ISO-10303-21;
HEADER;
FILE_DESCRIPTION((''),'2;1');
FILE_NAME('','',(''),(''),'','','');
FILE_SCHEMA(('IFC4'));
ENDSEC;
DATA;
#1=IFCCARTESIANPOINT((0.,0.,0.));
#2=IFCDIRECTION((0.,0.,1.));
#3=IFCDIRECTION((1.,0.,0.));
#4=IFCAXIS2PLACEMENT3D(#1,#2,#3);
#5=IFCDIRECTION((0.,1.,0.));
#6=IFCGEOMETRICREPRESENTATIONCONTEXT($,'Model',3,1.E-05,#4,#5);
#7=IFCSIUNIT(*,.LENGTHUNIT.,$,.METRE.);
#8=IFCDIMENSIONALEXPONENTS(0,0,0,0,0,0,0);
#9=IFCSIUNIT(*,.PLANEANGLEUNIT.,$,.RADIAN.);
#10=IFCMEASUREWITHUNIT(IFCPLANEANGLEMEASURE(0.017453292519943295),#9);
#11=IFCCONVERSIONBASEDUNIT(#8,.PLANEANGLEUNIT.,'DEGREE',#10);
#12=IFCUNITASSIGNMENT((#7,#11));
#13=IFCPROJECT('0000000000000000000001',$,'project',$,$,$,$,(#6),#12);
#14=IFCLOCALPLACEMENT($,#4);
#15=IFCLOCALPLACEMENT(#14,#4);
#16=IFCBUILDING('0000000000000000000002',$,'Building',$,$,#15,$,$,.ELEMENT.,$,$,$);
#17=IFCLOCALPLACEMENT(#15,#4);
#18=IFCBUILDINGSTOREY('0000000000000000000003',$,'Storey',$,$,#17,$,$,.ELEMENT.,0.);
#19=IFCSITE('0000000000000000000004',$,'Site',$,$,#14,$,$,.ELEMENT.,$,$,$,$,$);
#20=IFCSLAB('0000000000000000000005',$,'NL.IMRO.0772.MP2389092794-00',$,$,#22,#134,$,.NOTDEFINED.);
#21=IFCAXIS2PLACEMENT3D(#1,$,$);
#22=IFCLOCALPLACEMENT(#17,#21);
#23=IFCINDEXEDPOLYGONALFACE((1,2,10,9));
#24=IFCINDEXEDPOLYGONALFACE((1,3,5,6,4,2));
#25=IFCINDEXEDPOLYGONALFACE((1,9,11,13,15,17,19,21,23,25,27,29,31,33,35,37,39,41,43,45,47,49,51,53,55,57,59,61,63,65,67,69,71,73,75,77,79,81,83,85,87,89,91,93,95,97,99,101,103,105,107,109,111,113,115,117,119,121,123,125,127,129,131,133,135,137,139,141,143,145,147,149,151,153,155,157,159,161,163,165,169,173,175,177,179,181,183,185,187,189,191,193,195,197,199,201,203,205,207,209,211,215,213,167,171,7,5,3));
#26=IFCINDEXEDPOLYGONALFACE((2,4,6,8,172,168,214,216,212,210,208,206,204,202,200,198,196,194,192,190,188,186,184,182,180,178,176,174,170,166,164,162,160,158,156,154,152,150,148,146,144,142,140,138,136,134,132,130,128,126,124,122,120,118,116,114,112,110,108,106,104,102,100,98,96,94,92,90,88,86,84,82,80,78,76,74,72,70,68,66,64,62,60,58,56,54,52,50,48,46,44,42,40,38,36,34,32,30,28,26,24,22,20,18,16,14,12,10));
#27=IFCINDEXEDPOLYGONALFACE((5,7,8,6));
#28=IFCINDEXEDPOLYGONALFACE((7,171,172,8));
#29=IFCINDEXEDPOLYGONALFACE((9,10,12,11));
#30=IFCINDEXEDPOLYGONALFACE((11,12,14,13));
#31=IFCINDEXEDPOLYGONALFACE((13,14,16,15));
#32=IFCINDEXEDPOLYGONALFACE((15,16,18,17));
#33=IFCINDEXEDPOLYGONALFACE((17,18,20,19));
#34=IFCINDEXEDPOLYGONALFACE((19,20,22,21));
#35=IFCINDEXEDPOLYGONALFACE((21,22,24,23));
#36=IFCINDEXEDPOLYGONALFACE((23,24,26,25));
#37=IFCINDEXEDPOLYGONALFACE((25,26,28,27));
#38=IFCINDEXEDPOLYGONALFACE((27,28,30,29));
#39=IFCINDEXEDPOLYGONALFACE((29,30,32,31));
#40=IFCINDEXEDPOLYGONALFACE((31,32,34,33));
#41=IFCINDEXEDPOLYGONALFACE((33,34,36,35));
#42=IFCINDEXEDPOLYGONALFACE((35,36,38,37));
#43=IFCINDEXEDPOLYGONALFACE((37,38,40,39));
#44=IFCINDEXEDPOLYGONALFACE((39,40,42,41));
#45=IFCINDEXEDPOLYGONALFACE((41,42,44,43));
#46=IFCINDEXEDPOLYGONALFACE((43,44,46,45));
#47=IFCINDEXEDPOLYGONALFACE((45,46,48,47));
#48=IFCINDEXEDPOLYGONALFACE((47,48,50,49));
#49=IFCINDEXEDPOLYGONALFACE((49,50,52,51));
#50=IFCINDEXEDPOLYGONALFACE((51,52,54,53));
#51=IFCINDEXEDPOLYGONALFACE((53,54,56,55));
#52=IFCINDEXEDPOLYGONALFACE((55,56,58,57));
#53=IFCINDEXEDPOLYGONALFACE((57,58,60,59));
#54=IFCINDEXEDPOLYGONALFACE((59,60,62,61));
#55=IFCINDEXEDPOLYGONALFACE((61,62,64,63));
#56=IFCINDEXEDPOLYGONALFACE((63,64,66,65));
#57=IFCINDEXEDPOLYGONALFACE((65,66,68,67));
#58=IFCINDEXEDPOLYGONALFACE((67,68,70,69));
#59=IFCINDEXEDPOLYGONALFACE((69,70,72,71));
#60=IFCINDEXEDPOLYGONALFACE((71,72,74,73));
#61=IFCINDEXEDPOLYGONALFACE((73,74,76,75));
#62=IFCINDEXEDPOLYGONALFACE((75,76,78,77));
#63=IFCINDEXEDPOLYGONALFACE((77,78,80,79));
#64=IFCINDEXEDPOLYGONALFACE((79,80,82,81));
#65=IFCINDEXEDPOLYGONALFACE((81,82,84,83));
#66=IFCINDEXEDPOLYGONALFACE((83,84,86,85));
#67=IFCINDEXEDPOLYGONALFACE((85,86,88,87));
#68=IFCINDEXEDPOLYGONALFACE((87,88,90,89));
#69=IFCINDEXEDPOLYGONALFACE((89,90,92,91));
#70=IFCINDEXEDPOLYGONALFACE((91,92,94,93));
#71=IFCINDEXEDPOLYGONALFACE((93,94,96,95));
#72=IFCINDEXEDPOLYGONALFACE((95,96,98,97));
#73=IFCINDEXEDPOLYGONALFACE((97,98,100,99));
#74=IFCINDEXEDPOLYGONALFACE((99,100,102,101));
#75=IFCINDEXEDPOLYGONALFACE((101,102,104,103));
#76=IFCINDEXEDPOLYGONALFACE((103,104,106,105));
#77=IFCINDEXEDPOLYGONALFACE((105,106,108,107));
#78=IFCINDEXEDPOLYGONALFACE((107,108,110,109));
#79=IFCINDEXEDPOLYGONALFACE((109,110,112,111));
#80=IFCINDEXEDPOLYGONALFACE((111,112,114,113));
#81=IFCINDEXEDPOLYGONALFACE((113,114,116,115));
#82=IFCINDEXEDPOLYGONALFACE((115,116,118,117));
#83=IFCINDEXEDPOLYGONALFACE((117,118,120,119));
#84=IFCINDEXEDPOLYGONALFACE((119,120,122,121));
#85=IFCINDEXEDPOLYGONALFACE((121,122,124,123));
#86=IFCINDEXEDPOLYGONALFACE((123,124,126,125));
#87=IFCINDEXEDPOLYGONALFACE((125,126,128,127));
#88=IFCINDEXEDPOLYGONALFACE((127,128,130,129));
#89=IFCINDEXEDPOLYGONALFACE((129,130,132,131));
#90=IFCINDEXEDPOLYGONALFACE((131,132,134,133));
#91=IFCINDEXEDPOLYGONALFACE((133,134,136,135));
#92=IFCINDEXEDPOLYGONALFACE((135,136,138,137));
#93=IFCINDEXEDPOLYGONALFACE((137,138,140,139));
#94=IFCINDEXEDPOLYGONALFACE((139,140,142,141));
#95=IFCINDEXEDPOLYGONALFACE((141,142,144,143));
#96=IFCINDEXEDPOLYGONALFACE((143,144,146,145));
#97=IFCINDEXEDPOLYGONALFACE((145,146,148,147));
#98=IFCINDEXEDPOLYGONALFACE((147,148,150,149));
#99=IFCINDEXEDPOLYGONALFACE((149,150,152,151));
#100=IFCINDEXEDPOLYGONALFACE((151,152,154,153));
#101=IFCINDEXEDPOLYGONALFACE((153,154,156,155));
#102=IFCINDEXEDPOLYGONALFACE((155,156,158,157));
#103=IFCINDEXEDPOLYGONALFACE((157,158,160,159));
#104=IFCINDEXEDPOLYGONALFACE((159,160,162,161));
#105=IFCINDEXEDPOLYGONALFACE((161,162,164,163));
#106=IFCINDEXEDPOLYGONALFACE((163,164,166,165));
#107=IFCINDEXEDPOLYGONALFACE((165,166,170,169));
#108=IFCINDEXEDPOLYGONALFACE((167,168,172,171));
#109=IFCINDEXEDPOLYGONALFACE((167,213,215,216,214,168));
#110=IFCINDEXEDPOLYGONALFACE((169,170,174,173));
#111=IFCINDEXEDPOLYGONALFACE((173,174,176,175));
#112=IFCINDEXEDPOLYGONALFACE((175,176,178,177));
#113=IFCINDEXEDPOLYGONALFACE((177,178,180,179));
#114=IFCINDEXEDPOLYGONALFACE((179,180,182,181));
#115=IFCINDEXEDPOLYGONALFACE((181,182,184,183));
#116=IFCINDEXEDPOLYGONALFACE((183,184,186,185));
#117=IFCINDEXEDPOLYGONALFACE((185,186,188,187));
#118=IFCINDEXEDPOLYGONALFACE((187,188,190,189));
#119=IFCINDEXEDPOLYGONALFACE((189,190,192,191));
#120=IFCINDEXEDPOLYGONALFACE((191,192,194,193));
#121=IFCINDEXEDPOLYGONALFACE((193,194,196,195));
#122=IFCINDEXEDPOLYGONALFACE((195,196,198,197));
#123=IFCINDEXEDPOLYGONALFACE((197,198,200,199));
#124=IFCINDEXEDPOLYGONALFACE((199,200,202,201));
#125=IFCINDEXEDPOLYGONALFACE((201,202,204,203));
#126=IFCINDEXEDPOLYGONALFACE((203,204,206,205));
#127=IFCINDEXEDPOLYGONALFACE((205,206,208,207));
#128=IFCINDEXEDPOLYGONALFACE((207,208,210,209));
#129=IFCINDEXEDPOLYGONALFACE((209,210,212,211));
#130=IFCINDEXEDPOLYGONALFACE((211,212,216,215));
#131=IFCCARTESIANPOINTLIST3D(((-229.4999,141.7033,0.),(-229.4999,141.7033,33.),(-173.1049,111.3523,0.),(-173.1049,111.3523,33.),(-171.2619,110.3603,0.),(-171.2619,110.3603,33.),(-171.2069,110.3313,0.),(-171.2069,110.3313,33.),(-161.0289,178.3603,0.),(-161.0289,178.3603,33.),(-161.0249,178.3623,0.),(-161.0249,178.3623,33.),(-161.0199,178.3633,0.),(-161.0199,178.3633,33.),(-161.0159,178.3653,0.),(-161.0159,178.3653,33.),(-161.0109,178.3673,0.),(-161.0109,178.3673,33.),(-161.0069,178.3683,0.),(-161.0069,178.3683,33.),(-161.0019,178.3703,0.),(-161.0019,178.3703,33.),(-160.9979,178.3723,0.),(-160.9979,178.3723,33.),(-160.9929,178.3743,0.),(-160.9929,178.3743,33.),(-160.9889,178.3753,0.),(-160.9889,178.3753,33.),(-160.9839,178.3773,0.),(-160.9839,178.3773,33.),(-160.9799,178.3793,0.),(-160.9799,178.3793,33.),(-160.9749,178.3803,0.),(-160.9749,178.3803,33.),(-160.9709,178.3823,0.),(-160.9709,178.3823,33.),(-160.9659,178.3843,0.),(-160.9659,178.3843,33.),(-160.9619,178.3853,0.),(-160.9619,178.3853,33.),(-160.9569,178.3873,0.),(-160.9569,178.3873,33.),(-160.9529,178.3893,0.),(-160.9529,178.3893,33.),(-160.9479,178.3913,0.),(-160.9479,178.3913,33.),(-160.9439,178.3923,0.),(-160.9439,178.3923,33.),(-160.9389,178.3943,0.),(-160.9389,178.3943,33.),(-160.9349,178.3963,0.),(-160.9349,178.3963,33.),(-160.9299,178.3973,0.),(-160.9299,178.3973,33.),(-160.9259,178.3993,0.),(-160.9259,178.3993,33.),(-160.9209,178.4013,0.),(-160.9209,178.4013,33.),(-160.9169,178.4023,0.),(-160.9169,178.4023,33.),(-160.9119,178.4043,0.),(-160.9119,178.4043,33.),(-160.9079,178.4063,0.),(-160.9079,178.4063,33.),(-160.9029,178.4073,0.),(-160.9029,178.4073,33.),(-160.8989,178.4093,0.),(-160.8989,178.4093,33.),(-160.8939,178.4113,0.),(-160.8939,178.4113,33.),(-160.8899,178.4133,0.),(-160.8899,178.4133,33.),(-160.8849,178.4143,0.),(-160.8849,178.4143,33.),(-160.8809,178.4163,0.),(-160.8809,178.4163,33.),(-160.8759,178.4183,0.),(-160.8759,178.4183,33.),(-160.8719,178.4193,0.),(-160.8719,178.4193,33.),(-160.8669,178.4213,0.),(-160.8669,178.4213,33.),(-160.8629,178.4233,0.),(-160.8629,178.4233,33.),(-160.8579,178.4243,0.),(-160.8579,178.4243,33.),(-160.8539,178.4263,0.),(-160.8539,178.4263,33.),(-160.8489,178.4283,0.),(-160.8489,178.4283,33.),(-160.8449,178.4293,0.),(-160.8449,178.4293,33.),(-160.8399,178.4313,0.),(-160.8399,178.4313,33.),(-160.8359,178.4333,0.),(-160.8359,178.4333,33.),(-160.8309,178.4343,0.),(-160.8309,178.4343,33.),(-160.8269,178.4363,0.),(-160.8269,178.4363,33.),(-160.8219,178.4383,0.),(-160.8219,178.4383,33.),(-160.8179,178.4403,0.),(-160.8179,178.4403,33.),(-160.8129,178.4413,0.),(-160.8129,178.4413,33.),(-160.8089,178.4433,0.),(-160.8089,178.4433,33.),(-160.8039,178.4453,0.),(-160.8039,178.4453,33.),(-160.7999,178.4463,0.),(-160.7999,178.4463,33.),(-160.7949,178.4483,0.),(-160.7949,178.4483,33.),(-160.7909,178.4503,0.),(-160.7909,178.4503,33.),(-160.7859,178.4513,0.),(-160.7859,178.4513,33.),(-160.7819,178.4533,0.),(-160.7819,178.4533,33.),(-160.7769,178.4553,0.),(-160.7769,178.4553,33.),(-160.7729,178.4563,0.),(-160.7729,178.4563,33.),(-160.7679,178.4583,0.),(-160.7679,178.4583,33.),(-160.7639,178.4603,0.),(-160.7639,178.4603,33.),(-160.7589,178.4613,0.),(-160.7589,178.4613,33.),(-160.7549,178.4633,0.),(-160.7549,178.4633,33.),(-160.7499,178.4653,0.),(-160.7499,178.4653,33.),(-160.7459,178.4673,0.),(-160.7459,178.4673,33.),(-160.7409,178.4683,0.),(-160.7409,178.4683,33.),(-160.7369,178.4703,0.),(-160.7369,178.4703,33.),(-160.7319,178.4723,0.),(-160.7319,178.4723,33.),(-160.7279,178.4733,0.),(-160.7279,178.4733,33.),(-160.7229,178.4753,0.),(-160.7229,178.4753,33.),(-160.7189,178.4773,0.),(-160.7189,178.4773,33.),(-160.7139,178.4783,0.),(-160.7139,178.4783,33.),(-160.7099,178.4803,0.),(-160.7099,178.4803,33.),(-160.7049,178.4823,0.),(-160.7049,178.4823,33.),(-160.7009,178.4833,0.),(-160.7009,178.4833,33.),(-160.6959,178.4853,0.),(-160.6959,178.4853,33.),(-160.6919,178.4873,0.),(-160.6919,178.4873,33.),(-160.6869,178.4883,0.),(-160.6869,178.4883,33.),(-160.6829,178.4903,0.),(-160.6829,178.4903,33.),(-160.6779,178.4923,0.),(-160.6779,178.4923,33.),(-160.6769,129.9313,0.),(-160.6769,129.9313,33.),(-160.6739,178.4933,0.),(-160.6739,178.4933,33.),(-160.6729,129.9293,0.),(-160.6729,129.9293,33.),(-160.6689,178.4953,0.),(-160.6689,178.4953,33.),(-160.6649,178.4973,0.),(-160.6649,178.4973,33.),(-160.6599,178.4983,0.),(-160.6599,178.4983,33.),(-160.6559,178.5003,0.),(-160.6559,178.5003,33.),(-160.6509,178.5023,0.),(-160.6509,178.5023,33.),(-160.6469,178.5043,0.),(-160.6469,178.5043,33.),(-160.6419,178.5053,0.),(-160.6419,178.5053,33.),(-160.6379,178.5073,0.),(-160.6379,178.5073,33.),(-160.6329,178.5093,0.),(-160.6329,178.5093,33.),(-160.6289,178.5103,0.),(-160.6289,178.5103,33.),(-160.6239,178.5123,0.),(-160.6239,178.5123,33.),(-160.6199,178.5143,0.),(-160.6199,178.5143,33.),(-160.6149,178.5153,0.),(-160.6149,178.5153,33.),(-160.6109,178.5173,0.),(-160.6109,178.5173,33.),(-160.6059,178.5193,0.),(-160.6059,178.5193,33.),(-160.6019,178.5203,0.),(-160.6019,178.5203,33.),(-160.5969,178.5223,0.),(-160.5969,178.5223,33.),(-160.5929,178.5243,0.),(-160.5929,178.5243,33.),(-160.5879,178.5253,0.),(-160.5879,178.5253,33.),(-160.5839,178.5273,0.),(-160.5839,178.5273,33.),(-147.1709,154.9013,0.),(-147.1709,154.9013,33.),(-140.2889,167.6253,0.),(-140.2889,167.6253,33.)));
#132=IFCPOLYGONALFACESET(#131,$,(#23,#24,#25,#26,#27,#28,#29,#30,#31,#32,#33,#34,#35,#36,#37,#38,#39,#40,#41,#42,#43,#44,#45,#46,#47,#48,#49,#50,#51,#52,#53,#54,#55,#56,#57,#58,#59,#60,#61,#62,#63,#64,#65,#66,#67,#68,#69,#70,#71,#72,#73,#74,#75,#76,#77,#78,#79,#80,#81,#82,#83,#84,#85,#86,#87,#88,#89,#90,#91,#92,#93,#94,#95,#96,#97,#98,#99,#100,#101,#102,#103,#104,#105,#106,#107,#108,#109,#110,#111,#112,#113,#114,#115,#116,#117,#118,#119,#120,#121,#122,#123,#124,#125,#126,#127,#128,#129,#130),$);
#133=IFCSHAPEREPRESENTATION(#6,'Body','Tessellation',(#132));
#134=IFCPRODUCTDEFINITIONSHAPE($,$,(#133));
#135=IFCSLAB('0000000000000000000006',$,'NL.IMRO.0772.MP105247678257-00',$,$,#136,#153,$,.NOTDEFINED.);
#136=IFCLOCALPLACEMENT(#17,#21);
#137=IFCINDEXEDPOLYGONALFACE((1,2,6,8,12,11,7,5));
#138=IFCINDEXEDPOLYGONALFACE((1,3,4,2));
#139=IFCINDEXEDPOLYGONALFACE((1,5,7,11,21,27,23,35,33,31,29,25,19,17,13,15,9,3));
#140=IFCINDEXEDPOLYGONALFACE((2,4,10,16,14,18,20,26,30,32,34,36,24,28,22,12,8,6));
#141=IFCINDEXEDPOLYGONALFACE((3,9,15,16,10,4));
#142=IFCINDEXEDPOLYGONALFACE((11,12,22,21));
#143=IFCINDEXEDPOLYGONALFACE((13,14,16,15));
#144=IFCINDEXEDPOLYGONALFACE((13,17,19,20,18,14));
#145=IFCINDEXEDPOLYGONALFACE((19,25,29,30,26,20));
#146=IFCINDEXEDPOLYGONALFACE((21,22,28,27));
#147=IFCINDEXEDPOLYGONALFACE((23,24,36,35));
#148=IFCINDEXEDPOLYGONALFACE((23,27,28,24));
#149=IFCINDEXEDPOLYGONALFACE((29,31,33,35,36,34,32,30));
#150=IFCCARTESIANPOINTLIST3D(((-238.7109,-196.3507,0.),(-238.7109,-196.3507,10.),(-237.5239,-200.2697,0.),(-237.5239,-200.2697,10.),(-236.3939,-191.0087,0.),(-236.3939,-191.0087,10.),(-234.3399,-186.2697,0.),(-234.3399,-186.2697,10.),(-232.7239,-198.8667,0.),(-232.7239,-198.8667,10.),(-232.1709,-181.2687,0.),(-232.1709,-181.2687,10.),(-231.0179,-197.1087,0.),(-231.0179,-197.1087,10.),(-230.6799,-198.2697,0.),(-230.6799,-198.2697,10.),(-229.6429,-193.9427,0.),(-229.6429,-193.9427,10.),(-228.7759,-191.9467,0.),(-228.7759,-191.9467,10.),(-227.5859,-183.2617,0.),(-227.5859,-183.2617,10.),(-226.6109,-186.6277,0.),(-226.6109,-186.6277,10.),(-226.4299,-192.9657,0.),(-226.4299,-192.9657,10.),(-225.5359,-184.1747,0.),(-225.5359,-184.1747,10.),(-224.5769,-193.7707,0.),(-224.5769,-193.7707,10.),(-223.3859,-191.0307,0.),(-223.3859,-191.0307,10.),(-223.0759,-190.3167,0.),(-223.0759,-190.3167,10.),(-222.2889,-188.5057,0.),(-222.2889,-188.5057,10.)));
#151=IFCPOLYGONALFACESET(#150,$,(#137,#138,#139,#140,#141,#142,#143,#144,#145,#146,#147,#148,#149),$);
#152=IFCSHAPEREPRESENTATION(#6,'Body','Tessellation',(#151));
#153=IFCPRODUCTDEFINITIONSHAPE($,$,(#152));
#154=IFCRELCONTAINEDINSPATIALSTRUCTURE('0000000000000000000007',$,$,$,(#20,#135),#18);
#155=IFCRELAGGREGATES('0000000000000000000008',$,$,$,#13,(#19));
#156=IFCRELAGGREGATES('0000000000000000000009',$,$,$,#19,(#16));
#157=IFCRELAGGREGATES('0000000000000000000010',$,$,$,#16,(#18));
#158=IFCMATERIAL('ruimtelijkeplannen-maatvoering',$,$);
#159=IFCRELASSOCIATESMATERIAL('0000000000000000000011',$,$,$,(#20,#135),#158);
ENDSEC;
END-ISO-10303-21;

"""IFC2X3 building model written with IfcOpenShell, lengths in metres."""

from ifc_helpers import new_model, entity, si_unit, converted_unit, direction, origin_with_axes, place, context, project, spatial, polyline, outline, extrude, material, element, save


model = new_model("IFC2X3")

# Units and contexts
model_context = context("Model", 3, precision=1e-05, world=origin_with_axes(), true_north=direction((0.0, 1.0, 0.0)))
ifc_project = project(units=[si_unit("LENGTHUNIT", "METRE"), converted_unit("PLANEANGLEUNIT", "DEGREE", entity("IfcPlaneAngleMeasure", 0.017453292519943295), si_unit("PLANEANGLEUNIT", "RADIAN"), dimensions=[0, 0, 0, 0, 0, 0, 0])], contexts=[model_context])

# Site, building, storey
site_placement = place(None, origin_with_axes())
site = spatial("IfcSite", under=ifc_project, at=site_placement, Name="Site", CompositionType="ELEMENT")
building_placement = place(site_placement, origin_with_axes())
building = spatial("IfcBuilding", under=site, at=building_placement, Name="Building", CompositionType="ELEMENT")
storey_placement = place(building_placement, origin_with_axes())
storey = spatial("IfcBuildingStorey", under=building, at=storey_placement, Name="Storey", CompositionType="ELEMENT", Elevation=0.0)

# Slabs
ifc_material = material(Name="ruimtelijkeplannen-maatvoering")
slab_1_placement = place(storey_placement, origin_with_axes())
element("IfcSlab", 1, at=slab_1_placement, inside=storey, material=ifc_material, Name="NL.IMRO.0772.MP2389092794-00", PredefinedType="NOTDEFINED", context=model_context, shape_type="SweptSolid", body=[
    extrude(outline(polyline([(-161.0249, 178.3623), (-161.0199, 178.3633), (-161.0159, 178.3653), (-161.0109, 178.3673), (-161.0069, 178.3683), (-161.0019, 178.3703), (-160.9979, 178.3723), (-160.9929, 178.3743), (-160.9889, 178.3753), (-160.9839, 178.3773), (-160.9799, 178.3793), (-160.9749, 178.3803), (-160.9709, 178.3823), (-160.9659, 178.3843), (-160.9619, 178.3853), (-160.9569, 178.3873), (-160.9529, 178.3893), (-160.9479, 178.3913), (-160.9439, 178.3923), (-160.9389, 178.3943), (-160.9349, 178.3963), (-160.9299, 178.3973), (-160.9259, 178.3993), (-160.9209, 178.4013), (-160.9169, 178.4023), (-160.9119, 178.4043), (-160.9079, 178.4063), (-160.9029, 178.4073), (-160.8989, 178.4093), (-160.8939, 178.4113), (-160.8899, 178.4133), (-160.8849, 178.4143), (-160.8809, 178.4163), (-160.8759, 178.4183), (-160.8719, 178.4193), (-160.8669, 178.4213), (-160.8629, 178.4233), (-160.8579, 178.4243), (-160.8539, 178.4263), (-160.8489, 178.4283), (-160.8449, 178.4293), (-160.8399, 178.4313), (-160.8359, 178.4333), (-160.8309, 178.4343), (-160.8269, 178.4363), (-160.8219, 178.4383), (-160.8179, 178.4403), (-160.8129, 178.4413), (-160.8089, 178.4433), (-160.8039, 178.4453), (-160.7999, 178.4463), (-160.7949, 178.4483), (-160.7909, 178.4503), (-160.7859, 178.4513), (-160.7819, 178.4533), (-160.7769, 178.4553), (-160.7729, 178.4563), (-160.7679, 178.4583), (-160.7639, 178.4603), (-160.7589, 178.4613), (-160.7549, 178.4633), (-160.7499, 178.4653), (-160.7459, 178.4673), (-160.7409, 178.4683), (-160.7369, 178.4703), (-160.7319, 178.4723), (-160.7279, 178.4733), (-160.7229, 178.4753), (-160.7189, 178.4773), (-160.7139, 178.4783), (-160.7099, 178.4803), (-160.7049, 178.4823), (-160.7009, 178.4833), (-160.6959, 178.4853), (-160.6919, 178.4873), (-160.6869, 178.4883), (-160.6829, 178.4903), (-160.6779, 178.4923), (-160.6739, 178.4933), (-160.6689, 178.4953), (-160.6649, 178.4973), (-160.6599, 178.4983), (-160.6559, 178.5003), (-160.6509, 178.5023), (-160.6469, 178.5043), (-160.6419, 178.5053), (-160.6379, 178.5073), (-160.6329, 178.5093), (-160.6289, 178.5103), (-160.6239, 178.5123), (-160.6199, 178.5143), (-160.6149, 178.5153), (-160.6109, 178.5173), (-160.6059, 178.5193), (-160.6019, 178.5203), (-160.5969, 178.5223), (-160.5929, 178.5243), (-160.5879, 178.5253), (-160.5839, 178.5273), (-140.2889, 167.6253), (-147.1709, 154.9013), (-160.6769, 129.9313), (-160.6729, 129.9293), (-171.2069, 110.3313), (-171.2619, 110.3603), (-173.1049, 111.3523), (-229.4999, 141.7033), (-161.0289, 178.3603), (-161.0249, 178.3623)])), origin_with_axes(), (0.0, 0.0, 1.0), 33.0),
])
slab_2_placement = place(storey_placement, origin_with_axes())
element("IfcSlab", 2, at=slab_2_placement, inside=storey, material=ifc_material, Name="NL.IMRO.0772.MP105247678257-00", PredefinedType="NOTDEFINED", context=model_context, shape_type="SweptSolid", body=[
    extrude(outline(polyline([(-223.0759, -190.3167), (-223.3859, -191.0307), (-224.5769, -193.7707), (-226.4299, -192.9657), (-228.7759, -191.9467), (-229.6429, -193.9427), (-231.0179, -197.1087), (-230.6799, -198.2697), (-232.7239, -198.8667), (-237.5239, -200.2697), (-238.7109, -196.3507), (-236.3939, -191.0087), (-234.3399, -186.2697), (-232.1709, -181.2687), (-227.5859, -183.2617), (-225.5359, -184.1747), (-226.6109, -186.6277), (-222.2889, -188.5057), (-223.0759, -190.3167)])), origin_with_axes(), (0.0, 0.0, 1.0), 10.0),
])

save(model, "model.ifc")
